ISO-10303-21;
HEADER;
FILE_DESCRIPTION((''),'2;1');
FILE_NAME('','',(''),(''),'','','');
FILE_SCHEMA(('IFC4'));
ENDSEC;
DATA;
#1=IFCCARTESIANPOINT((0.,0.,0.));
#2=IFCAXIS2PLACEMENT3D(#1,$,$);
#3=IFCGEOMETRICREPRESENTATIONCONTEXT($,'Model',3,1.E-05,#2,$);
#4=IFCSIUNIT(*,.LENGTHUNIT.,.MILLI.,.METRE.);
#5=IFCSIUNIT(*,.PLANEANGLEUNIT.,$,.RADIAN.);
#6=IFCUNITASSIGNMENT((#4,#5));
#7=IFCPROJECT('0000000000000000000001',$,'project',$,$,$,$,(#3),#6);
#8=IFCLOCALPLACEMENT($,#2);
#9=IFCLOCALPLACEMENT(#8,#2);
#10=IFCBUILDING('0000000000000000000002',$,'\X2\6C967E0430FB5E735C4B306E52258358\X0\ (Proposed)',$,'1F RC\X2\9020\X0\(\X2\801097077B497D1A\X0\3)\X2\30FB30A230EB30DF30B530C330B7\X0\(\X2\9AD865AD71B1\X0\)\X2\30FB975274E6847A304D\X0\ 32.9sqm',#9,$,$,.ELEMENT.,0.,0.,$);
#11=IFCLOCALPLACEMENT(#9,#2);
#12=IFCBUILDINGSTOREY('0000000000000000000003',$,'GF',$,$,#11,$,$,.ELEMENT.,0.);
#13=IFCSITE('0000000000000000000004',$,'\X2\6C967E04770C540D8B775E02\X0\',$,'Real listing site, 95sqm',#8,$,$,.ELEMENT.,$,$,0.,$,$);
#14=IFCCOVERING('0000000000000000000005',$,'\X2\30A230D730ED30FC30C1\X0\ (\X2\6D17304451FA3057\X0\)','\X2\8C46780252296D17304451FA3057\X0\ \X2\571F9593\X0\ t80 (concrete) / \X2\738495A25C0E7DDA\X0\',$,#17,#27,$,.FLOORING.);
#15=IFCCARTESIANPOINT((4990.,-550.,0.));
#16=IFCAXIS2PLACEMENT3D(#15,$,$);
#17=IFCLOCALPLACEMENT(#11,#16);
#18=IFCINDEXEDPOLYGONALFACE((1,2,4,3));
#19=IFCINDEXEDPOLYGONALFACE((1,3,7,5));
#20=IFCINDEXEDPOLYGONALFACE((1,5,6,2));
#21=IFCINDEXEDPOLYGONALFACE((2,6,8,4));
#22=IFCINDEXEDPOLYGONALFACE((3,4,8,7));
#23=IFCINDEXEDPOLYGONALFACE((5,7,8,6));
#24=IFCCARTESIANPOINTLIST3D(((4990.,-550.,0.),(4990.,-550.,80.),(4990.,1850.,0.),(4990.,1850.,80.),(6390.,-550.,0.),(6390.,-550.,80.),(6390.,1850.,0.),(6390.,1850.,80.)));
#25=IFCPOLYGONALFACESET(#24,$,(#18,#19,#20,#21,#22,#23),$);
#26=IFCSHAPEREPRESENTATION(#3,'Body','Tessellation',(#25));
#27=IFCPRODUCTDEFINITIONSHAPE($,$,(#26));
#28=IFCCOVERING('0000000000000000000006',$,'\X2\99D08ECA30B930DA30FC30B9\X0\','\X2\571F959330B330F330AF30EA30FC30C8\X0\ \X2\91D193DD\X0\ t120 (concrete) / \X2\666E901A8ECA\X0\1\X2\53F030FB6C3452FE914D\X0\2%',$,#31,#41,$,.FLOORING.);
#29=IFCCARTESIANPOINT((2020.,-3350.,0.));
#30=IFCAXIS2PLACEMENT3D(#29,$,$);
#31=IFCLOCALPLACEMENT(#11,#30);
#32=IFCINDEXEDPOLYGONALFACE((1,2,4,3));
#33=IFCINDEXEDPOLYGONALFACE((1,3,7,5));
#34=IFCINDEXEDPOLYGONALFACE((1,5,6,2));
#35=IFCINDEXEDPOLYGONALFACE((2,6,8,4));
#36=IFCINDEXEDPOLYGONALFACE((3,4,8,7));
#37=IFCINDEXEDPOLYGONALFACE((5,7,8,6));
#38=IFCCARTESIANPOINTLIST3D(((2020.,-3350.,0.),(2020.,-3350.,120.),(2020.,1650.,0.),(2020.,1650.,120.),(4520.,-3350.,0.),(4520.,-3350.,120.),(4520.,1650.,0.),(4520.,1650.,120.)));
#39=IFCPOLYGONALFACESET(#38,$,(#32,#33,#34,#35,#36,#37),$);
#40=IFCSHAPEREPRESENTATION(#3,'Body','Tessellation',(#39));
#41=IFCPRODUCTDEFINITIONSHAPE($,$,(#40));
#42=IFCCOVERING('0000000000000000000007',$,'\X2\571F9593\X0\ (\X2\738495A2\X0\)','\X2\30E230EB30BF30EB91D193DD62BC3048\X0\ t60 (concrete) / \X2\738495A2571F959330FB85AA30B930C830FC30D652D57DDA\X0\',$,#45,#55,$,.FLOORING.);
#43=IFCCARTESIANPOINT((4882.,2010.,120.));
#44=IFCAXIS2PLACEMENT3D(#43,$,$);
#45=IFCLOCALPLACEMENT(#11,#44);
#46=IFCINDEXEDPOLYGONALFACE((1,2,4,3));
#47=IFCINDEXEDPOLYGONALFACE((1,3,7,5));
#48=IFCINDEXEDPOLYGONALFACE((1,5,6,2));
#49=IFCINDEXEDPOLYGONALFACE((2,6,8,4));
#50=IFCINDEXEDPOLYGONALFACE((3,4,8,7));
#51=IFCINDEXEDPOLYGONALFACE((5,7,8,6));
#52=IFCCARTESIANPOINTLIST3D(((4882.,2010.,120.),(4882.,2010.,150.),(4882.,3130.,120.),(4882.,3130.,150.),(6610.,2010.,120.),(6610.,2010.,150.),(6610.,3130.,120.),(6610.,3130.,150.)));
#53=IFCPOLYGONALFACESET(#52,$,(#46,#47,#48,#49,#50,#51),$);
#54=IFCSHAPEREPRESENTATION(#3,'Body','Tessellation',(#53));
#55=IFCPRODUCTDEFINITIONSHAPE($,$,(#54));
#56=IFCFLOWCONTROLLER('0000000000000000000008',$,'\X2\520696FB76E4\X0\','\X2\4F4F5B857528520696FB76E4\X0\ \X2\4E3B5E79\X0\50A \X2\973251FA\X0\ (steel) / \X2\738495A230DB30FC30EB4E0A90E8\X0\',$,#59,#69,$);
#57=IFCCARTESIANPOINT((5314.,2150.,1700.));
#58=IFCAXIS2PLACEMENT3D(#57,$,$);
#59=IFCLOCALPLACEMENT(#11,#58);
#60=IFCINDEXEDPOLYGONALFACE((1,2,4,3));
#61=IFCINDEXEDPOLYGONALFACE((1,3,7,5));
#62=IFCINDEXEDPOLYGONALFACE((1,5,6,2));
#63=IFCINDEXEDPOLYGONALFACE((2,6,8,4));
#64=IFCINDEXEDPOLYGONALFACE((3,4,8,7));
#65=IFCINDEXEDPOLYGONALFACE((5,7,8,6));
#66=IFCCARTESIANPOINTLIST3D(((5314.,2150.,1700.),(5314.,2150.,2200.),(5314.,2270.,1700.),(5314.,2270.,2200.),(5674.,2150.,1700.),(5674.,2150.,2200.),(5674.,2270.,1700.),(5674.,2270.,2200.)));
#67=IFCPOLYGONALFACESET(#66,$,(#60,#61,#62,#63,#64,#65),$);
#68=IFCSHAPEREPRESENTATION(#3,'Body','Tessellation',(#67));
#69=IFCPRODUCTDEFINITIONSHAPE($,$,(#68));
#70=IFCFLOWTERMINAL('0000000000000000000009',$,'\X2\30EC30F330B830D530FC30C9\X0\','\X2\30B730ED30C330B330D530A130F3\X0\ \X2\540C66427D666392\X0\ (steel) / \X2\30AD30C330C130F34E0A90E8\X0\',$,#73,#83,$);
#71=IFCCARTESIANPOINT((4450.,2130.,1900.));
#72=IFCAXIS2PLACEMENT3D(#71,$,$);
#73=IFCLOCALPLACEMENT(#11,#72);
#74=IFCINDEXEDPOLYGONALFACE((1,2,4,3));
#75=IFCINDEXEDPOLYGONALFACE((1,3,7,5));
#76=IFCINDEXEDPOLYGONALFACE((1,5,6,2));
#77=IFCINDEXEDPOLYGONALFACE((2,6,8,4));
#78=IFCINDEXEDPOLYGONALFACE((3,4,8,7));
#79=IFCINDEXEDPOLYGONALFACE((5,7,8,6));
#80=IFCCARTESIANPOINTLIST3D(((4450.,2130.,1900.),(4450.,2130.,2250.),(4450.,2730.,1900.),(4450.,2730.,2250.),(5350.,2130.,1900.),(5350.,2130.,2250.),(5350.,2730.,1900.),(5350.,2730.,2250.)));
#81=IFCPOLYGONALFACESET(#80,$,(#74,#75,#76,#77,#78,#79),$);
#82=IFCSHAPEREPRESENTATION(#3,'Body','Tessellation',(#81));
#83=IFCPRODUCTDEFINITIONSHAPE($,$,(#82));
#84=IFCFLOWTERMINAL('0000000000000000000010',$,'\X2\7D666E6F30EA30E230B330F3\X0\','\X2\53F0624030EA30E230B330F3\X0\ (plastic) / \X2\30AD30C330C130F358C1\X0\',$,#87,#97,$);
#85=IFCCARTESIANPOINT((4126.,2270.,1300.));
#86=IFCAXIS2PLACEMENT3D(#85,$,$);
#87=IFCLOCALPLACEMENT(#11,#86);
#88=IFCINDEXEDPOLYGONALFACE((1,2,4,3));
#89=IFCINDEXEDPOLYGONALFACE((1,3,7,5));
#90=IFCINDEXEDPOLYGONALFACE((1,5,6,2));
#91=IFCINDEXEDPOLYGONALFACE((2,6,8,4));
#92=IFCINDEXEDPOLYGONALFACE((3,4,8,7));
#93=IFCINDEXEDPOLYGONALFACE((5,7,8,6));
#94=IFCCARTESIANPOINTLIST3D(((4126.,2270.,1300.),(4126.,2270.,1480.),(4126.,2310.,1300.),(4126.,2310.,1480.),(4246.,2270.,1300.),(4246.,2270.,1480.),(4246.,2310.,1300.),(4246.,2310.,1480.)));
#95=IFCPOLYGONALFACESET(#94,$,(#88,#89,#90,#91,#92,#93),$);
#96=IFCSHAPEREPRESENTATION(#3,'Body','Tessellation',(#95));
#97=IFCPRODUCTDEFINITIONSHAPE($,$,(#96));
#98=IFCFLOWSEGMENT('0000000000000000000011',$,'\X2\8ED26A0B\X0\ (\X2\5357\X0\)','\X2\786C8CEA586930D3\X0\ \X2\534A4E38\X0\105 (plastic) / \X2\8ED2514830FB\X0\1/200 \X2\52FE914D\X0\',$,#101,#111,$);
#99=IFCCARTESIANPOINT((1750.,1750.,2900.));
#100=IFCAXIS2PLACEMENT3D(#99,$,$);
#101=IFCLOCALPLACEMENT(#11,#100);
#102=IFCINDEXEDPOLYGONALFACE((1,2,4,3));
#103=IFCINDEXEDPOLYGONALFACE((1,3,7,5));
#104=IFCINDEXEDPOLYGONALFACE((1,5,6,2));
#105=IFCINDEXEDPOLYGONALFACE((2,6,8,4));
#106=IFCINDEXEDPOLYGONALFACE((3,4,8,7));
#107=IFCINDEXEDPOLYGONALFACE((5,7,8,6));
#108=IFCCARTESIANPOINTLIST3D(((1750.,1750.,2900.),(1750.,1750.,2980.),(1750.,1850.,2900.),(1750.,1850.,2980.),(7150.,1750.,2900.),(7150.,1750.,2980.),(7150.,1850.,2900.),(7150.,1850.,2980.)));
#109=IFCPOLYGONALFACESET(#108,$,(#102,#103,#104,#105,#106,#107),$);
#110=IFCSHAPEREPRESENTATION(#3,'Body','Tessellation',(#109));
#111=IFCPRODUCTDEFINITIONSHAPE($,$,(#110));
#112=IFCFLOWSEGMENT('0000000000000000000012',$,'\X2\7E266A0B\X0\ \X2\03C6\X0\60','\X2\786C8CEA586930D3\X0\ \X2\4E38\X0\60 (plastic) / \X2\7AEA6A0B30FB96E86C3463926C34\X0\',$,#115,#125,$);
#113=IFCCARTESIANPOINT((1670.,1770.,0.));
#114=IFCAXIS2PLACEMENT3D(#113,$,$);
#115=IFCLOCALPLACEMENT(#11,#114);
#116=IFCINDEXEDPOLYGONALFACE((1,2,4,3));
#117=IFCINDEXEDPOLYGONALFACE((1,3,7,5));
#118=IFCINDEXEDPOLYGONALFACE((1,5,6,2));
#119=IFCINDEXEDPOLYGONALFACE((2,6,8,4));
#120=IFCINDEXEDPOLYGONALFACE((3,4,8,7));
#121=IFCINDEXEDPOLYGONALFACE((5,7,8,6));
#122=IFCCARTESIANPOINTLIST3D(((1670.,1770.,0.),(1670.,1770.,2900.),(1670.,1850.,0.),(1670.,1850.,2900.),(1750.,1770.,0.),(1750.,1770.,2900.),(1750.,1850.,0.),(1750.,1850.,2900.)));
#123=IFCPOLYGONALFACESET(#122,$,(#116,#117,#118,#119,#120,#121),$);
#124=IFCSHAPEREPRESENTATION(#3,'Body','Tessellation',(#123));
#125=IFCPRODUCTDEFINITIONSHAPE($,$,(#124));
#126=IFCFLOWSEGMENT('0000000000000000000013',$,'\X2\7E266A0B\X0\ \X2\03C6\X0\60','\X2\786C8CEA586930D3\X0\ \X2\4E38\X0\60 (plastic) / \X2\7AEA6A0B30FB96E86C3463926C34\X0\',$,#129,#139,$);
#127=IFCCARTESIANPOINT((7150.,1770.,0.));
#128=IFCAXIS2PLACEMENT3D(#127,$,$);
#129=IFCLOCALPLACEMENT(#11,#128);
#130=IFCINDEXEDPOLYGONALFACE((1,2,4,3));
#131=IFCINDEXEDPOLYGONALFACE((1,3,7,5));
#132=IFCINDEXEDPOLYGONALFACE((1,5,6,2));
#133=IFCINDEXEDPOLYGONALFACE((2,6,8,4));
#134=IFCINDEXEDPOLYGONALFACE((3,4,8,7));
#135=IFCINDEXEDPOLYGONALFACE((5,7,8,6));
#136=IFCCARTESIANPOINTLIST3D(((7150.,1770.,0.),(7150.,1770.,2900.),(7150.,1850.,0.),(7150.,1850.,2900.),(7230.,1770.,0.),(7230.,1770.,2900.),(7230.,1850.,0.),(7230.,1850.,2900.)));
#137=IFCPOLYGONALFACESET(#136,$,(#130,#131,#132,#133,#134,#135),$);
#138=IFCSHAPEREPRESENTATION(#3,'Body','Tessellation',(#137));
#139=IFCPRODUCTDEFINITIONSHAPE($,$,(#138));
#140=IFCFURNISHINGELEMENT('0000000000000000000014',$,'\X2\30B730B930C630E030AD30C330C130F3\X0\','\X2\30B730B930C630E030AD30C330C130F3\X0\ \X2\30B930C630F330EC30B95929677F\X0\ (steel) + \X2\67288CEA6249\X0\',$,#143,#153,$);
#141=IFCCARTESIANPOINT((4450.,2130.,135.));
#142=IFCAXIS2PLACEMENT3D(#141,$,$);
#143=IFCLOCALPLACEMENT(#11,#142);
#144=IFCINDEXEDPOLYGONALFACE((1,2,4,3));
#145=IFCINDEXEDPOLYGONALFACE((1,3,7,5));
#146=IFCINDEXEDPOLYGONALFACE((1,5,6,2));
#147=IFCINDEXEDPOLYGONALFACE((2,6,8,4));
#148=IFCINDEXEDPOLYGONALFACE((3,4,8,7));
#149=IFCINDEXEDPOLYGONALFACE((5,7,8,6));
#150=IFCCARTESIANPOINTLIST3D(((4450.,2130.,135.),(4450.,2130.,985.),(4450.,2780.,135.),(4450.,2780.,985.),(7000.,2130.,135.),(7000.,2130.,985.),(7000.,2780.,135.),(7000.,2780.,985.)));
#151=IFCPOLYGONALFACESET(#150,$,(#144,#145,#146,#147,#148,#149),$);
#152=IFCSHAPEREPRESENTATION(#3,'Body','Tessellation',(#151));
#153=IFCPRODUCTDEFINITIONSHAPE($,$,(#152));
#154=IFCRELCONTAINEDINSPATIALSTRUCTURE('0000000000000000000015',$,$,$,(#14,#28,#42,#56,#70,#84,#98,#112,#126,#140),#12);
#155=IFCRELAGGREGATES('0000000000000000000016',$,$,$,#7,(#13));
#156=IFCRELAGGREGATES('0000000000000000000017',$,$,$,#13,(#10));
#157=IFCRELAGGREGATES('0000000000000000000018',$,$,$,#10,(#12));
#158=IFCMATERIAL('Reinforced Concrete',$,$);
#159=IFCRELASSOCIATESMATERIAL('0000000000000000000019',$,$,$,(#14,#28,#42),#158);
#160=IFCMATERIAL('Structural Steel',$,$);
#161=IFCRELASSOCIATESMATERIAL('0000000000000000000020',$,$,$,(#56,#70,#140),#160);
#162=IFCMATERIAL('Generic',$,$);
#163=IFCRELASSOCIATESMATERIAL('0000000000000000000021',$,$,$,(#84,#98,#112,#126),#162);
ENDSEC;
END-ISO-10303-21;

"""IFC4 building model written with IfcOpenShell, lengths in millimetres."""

from ifc_helpers import new_model, si_unit, frame, frame_2d, origin, place, context, project, spatial, rectangle, extrude, material, element, save


model = new_model("IFC4")

# Units and contexts
model_context = context("Model", 3, precision=1e-05, world=origin())
ifc_project = project(units=[si_unit("LENGTHUNIT", "METRE", prefix="MILLI"), si_unit("PLANEANGLEUNIT", "RADIAN")], contexts=[model_context])

# Site, building, storey
site_placement = place(None, origin())
site = spatial("IfcSite", under=ifc_project, at=site_placement, Name="沖縄県名護市", ObjectType="Real listing site, 95sqm", CompositionType="ELEMENT", RefElevation=0.0)
building_placement = place(site_placement, origin())
building = spatial("IfcBuilding", under=site, at=building_placement, Name="沖縄・平屋の別荘 (Proposed)", ObjectType="1F RC造(耐震等級3)・アルミサッシ(高断熱)・青瓦葺き 32.9sqm", CompositionType="ELEMENT", ElevationOfRefHeight=0.0, ElevationOfTerrain=0.0)
storey_placement = place(building_placement, origin())
storey = spatial("IfcBuildingStorey", under=building, at=storey_placement, Name="GF", CompositionType="ELEMENT", Elevation=0.0)

# Shared definitions
ifc_material_1 = material(Name="Reinforced Concrete")

# Shared definitions
ifc_material_2 = material(Name="Structural Steel")

# Coverings
ifc_material_3 = material(Name="Generic")
covering_1_placement = place(storey_placement, frame((4990.0, -550.0, 0.0)))
element("IfcCovering", 1, at=covering_1_placement, inside=storey, material=ifc_material_1, Name="アプローチ (洗い出し)", Description="豆砂利洗い出し 土間 t80 (concrete) / 玄関導線", PredefinedType="FLOORING", context=model_context, shape_type="SweptSolid", body=[
    extrude(rectangle(XDim=1400.0, YDim=2400.0, at=frame_2d((700.0, 1200.0))), frame((4990.0, -550.0, 0.0)), (0.0, 0.0, 1.0), 80.0),
])
covering_2_placement = place(storey_placement, frame((2020.0, -3350.0, 0.0)))
element("IfcCovering", 2, at=covering_2_placement, inside=storey, material=ifc_material_1, Name="駐車スペース", Description="土間コンクリート 金鏝 t120 (concrete) / 普通車1台・水勾配2%", PredefinedType="FLOORING", context=model_context, shape_type="SweptSolid", body=[
    extrude(rectangle(XDim=2500.0, YDim=5000.0, at=frame_2d((1250.0, 2500.0))), frame((2020.0, -3350.0, 0.0)), (0.0, 0.0, 1.0), 120.0),
])
covering_3_placement = place(storey_placement, frame((4882.0, 2010.0, 120.0)))
element("IfcCovering", 3, at=covering_3_placement, inside=storey, material=ifc_material_1, Name="土間 (玄関)", Description="モルタル金鏝押え t60 (concrete) / 玄関土間・薪ストーブ動線", PredefinedType="FLOORING", context=model_context, shape_type="SweptSolid", body=[
    extrude(rectangle(XDim=1728.0, YDim=1120.0, at=frame_2d((864.0, 560.0))), frame((4882.0, 2010.0, 120.0)), (0.0, 0.0, 1.0), 30.0),
])

# Flow controller
flow_controller_placement = place(storey_placement, frame((5314.0, 2150.0, 1700.0)))
element("IfcFlowController", 4, at=flow_controller_placement, inside=storey, material=ifc_material_2, Name="分電盤", Description="住宅用分電盤 主幹50A 露出 (steel) / 玄関ホール上部", context=model_context, shape_type="SweptSolid", body=[
    extrude(rectangle(XDim=360.0, YDim=120.0, at=frame_2d((180.0, 60.0))), frame((5314.0, 2150.0, 1700.0)), (0.0, 0.0, 1.0), 500.0),
])

# Flow terminals
flow_terminal_1_placement = place(storey_placement, frame((4450.0, 2130.0, 1900.0)))
element("IfcFlowTerminal", 5, at=flow_terminal_1_placement, inside=storey, material=ifc_material_2, Name="レンジフード", Description="シロッコファン 同時給排 (steel) / キッチン上部", context=model_context, shape_type="SweptSolid", body=[
    extrude(rectangle(XDim=900.0, YDim=600.0, at=frame_2d((450.0, 300.0))), frame((4450.0, 2130.0, 1900.0)), (0.0, 0.0, 1.0), 350.0),
])
flow_terminal_2_placement = place(storey_placement, frame((4126.0, 2270.0, 1300.0)))
element("IfcFlowTerminal", 6, at=flow_terminal_2_placement, inside=storey, material=ifc_material_3, Name="給湯リモコン", Description="台所リモコン (plastic) / キッチン壁", context=model_context, shape_type="SweptSolid", body=[
    extrude(rectangle(XDim=120.0, YDim=40.0, at=frame_2d((60.0, 20.0))), frame((4126.0, 2270.0, 1300.0)), (0.0, 0.0, 1.0), 180.0),
])

# Flow segments
flow_segment_1_placement = place(storey_placement, frame((1750.0, 1750.0, 2900.0)))
element("IfcFlowSegment", 7, at=flow_segment_1_placement, inside=storey, material=ifc_material_3, Name="軒樋 (南)", Description="硬質塩ビ 半丸105 (plastic) / 軒先・1/200 勾配", context=model_context, shape_type="SweptSolid", body=[
    extrude(rectangle(XDim=5400.0, YDim=100.0, at=frame_2d((2700.0, 50.0))), frame((1750.0, 1750.0, 2900.0)), (0.0, 0.0, 1.0), 80.0),
])
flow_segment_2_placement = place(storey_placement, frame((1670.0, 1770.0, 0.0)))
element("IfcFlowSegment", 8, at=flow_segment_2_placement, inside=storey, material=ifc_material_3, Name="縦樋 φ60", Description="硬質塩ビ 丸60 (plastic) / 竪樋・雨水排水", context=model_context, shape_type="SweptSolid", body=[
    extrude(rectangle(XDim=80.0, YDim=80.0, at=frame_2d((40.0, 40.0))), frame((1670.0, 1770.0, 0.0)), (0.0, 0.0, 1.0), 2900.0),
])
flow_segment_3_placement = place(storey_placement, frame((7150.0, 1770.0, 0.0)))
element("IfcFlowSegment", 9, at=flow_segment_3_placement, inside=storey, material=ifc_material_3, Name="縦樋 φ60", Description="硬質塩ビ 丸60 (plastic) / 竪樋・雨水排水", context=model_context, shape_type="SweptSolid", body=[
    extrude(rectangle(XDim=80.0, YDim=80.0, at=frame_2d((40.0, 40.0))), frame((7150.0, 1770.0, 0.0)), (0.0, 0.0, 1.0), 2900.0),
])

# Furnishing element
furnishing_placement = place(storey_placement, frame((4450.0, 2130.0, 135.0)))
element("IfcFurnishingElement", 10, at=furnishing_placement, inside=storey, material=ifc_material_2, Name="システムキッチン", Description="システムキッチン ステンレス天板 (steel) + 木質扉", context=model_context, shape_type="SweptSolid", body=[
    extrude(rectangle(XDim=2550.0, YDim=650.0, at=frame_2d((1275.0, 325.0))), frame((4450.0, 2130.0, 135.0)), (0.0, 0.0, 1.0), 850.0),
])

save(model, "model.ifc")
